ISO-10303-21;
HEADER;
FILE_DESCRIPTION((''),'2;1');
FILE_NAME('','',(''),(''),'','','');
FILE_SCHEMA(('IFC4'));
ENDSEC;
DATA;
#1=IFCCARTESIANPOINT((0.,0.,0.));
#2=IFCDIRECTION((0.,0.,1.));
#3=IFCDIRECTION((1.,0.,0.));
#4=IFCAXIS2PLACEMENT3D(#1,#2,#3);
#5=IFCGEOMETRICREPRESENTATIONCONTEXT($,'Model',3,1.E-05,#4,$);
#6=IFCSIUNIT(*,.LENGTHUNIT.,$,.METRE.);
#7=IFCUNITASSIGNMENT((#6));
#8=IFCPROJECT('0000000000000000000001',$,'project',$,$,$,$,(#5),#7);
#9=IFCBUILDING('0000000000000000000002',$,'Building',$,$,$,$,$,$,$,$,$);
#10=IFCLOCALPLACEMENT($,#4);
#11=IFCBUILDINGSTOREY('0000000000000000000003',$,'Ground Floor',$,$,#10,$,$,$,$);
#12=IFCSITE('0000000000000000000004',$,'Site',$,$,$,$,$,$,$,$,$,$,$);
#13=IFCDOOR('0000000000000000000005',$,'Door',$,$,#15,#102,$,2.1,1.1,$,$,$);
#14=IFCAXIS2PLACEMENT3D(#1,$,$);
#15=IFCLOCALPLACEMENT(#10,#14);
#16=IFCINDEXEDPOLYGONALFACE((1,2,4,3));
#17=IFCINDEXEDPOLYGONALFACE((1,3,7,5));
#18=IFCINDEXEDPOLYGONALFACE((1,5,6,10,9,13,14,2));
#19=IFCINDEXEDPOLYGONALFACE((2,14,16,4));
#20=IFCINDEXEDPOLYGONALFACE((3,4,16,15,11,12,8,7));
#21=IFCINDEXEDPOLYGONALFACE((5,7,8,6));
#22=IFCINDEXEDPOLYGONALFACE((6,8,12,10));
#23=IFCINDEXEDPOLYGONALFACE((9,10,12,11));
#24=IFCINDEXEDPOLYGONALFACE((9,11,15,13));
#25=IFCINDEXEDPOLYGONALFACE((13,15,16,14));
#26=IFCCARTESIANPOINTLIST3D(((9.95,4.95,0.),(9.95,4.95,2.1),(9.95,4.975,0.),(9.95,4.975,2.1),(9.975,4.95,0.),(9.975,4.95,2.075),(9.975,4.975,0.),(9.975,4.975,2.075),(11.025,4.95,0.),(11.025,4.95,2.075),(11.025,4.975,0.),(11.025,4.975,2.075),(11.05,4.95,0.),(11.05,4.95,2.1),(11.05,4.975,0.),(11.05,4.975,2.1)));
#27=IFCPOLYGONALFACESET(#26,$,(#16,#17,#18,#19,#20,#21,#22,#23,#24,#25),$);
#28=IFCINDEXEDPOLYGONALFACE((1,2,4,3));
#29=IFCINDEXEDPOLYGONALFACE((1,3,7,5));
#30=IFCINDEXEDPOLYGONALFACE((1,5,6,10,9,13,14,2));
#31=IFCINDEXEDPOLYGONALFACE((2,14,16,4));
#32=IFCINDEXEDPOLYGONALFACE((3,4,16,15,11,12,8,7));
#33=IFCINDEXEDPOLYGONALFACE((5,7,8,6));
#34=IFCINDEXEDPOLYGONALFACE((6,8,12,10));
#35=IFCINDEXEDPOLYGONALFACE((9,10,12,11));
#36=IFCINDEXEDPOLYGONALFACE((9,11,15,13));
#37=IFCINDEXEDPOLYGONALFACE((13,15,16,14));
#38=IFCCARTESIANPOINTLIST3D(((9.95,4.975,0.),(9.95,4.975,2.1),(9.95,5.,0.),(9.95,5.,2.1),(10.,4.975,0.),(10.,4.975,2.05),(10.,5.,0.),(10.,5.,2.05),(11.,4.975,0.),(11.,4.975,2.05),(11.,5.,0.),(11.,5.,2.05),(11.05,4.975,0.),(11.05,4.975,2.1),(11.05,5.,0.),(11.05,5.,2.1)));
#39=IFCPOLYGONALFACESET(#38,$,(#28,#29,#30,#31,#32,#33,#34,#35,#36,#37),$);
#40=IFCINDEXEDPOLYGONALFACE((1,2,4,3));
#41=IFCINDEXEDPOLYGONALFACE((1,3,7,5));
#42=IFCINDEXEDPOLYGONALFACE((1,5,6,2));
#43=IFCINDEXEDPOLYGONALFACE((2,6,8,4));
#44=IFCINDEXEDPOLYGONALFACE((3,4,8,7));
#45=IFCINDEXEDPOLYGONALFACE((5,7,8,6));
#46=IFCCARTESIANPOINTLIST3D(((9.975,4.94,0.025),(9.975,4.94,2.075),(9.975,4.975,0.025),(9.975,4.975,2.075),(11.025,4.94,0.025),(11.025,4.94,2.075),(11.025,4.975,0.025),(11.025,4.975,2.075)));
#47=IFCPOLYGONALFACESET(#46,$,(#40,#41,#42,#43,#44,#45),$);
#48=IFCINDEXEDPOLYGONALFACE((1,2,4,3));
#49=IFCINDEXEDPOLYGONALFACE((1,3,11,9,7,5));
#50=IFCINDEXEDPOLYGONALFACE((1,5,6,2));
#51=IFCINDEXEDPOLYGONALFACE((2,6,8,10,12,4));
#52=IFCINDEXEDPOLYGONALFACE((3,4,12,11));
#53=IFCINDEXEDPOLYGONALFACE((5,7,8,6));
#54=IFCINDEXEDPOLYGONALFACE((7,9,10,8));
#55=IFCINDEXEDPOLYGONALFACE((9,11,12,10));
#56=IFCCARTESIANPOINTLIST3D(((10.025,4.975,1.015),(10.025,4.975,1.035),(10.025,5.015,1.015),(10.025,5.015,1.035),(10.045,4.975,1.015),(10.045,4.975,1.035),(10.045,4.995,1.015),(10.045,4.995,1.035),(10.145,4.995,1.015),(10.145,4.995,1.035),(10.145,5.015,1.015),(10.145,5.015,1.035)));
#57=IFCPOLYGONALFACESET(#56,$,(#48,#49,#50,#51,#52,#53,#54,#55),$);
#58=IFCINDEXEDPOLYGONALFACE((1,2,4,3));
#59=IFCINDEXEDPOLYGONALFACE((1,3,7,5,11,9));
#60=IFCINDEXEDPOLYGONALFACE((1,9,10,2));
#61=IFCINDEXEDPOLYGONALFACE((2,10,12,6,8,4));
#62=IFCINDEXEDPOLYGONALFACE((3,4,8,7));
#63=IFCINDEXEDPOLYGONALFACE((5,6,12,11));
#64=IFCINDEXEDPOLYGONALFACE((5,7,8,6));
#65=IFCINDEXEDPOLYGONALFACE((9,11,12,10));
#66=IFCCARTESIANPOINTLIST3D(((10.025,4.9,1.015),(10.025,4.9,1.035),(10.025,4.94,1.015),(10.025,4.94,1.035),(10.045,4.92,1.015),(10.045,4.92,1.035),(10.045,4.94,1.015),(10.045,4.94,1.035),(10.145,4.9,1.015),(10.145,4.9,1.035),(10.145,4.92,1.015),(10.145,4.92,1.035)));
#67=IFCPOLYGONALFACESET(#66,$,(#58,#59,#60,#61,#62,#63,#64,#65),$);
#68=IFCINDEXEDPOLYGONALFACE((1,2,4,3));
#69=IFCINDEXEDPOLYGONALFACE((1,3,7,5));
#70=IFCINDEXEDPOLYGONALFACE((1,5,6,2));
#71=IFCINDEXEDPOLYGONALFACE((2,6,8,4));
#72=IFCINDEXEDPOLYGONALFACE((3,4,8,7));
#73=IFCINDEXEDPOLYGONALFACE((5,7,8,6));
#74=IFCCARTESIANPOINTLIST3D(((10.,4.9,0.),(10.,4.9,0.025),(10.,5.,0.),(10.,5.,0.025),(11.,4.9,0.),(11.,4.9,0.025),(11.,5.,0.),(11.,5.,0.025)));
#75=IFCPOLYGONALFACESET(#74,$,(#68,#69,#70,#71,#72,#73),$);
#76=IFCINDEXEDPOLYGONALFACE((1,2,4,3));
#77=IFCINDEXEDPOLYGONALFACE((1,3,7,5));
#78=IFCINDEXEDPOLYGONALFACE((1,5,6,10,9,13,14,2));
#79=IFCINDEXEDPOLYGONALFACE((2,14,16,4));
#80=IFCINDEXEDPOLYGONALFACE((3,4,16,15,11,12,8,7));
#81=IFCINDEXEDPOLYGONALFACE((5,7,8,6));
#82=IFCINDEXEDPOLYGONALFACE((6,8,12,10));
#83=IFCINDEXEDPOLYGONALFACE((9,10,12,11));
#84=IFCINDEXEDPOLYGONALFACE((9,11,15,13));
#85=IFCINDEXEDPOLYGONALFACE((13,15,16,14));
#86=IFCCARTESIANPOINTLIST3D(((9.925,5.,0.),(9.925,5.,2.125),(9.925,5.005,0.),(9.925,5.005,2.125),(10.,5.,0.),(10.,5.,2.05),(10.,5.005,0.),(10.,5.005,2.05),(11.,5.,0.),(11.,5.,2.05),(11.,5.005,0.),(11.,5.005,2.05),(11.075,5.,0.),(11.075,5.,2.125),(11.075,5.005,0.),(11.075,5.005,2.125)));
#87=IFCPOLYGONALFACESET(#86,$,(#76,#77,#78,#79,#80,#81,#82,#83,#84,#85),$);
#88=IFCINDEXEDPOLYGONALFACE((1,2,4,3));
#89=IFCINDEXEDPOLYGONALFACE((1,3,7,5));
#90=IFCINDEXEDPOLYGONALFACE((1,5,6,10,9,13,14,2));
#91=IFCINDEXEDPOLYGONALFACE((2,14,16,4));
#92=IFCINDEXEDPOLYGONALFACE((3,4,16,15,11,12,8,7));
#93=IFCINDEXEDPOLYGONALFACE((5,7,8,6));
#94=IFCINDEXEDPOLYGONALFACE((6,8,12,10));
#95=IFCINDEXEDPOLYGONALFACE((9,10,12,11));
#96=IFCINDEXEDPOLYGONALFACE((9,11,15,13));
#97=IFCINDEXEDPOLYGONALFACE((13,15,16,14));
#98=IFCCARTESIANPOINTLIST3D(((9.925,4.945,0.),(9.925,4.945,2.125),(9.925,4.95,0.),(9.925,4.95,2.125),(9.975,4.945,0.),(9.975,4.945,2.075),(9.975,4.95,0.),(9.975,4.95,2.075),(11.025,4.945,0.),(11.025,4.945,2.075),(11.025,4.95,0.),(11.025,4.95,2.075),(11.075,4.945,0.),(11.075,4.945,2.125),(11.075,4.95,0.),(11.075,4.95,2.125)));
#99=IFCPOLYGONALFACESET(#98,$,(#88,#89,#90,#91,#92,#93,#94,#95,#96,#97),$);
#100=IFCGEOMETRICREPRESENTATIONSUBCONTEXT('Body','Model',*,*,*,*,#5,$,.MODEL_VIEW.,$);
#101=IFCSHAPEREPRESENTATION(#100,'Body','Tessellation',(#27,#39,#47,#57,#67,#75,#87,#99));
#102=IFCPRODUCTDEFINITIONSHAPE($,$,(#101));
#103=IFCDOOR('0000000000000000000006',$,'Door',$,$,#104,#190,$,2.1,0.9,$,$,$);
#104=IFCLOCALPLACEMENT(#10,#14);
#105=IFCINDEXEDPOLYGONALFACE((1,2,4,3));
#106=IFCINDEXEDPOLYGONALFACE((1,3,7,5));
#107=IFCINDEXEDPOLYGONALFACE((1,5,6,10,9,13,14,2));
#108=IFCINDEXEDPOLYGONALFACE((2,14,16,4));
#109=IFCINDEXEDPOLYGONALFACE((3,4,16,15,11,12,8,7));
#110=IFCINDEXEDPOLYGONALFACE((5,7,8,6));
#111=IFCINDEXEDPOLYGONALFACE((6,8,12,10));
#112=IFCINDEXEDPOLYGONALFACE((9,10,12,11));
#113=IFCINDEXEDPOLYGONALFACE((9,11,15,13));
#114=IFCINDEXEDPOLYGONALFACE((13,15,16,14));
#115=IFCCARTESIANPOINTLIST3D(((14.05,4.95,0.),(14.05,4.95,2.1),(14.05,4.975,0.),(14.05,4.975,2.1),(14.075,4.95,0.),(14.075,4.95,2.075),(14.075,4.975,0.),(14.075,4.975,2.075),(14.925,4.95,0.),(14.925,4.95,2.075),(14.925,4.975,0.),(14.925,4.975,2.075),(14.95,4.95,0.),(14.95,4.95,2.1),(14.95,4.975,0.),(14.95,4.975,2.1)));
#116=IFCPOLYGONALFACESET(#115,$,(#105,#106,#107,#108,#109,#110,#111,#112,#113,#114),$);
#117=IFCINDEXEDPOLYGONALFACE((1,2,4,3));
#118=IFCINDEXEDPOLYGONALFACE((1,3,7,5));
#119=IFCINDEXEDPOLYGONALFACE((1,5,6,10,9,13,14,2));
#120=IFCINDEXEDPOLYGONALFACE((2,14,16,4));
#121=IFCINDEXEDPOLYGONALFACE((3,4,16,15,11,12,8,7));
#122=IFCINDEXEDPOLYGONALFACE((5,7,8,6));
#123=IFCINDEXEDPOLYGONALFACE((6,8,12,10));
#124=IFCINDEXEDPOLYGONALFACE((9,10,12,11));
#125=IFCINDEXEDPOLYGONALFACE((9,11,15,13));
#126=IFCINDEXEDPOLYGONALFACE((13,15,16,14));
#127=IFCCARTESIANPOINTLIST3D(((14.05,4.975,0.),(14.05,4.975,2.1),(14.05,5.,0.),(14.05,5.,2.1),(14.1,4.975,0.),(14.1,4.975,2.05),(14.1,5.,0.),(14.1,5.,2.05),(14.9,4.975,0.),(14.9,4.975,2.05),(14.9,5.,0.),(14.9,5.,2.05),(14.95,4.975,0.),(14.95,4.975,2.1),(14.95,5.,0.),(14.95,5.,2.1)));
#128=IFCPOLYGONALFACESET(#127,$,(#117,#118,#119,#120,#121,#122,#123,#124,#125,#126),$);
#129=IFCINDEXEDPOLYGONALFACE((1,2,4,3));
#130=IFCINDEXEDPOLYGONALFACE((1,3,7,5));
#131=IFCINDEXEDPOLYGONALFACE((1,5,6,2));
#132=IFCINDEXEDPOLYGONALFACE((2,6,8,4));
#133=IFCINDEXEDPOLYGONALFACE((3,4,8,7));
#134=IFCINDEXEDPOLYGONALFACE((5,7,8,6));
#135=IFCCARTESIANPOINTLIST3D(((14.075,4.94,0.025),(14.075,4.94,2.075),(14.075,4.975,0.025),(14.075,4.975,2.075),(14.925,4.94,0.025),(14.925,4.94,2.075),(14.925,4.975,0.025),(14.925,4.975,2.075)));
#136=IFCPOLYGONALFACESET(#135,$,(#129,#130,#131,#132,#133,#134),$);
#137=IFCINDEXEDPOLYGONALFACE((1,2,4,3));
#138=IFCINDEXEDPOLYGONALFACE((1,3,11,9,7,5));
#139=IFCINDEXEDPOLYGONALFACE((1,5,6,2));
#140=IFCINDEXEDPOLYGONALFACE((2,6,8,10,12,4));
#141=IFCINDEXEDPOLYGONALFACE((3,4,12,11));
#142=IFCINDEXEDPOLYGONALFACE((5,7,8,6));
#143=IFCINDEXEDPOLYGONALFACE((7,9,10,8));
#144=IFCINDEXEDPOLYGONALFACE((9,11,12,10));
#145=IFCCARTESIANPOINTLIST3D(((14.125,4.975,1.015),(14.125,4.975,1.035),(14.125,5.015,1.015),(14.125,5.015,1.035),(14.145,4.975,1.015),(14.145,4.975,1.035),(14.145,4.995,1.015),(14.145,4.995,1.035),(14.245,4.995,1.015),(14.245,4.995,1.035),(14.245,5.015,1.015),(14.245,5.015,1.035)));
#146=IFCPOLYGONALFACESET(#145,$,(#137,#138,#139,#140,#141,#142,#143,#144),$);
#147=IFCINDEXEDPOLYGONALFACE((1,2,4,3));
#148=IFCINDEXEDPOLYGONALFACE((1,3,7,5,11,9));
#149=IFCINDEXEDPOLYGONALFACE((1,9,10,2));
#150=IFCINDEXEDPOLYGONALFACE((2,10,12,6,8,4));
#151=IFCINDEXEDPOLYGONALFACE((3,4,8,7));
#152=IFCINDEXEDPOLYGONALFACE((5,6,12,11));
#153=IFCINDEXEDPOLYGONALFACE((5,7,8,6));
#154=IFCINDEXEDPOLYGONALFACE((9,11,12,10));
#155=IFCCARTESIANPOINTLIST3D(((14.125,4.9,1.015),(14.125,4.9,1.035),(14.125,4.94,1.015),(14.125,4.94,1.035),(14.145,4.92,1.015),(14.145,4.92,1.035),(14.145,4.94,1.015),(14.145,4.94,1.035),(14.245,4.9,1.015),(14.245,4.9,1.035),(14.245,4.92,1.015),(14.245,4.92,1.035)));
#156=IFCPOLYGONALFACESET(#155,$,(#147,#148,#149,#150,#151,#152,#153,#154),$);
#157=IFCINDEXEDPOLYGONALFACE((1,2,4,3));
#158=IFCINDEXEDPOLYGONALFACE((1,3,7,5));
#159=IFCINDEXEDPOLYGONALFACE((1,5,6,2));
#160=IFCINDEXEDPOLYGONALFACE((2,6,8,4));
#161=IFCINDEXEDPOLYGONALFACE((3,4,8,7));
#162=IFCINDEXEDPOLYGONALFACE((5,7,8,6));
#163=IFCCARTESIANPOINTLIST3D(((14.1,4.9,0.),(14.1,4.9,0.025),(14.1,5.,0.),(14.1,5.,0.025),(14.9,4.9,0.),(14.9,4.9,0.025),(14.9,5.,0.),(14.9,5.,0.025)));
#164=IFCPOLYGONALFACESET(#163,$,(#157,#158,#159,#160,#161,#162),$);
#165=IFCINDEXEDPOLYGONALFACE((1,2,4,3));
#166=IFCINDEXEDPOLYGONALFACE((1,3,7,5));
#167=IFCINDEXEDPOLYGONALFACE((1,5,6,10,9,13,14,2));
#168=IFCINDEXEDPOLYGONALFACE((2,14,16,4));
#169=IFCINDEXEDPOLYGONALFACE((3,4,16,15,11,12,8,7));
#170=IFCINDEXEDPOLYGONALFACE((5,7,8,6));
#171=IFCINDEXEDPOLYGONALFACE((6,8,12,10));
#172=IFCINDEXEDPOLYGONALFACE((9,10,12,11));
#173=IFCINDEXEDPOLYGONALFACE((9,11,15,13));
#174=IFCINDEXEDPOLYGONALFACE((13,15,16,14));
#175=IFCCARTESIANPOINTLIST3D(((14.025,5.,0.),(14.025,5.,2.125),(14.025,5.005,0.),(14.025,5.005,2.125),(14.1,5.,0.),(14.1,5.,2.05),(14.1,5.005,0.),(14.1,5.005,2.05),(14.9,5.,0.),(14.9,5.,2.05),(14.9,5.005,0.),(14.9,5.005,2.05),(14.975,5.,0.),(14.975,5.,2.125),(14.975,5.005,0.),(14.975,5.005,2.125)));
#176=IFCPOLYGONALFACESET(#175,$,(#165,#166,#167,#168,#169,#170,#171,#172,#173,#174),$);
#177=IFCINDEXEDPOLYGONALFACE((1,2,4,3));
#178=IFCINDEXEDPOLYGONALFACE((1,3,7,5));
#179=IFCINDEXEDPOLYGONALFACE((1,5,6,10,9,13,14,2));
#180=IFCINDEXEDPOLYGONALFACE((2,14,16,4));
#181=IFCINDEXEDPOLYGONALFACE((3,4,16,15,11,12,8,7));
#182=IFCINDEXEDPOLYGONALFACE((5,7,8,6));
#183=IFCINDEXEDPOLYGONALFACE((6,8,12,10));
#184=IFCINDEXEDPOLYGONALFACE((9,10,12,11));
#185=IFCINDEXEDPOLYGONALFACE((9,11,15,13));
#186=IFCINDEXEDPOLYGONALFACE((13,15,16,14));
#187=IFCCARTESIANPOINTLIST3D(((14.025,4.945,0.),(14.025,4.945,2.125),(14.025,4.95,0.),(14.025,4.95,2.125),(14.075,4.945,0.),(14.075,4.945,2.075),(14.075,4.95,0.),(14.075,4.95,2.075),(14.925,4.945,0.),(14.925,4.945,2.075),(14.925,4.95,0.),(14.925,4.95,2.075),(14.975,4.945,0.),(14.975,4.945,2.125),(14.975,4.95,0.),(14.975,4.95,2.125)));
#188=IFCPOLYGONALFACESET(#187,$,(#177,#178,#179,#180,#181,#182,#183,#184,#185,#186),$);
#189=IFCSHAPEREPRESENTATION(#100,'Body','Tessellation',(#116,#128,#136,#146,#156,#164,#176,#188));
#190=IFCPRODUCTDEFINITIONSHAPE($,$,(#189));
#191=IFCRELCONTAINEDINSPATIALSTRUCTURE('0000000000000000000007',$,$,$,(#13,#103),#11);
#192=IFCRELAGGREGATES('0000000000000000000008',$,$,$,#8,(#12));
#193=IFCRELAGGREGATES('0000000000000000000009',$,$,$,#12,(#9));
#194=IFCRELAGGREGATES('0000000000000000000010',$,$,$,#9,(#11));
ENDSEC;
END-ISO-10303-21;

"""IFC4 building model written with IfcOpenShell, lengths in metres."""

from ifc_helpers import new_model, si_unit, frame, origin_with_axes, place, context, subcontext, project, spatial, line, indexed_curve, outline, extrude, element, save


model = new_model("IFC4")

# Units and contexts
model_context = context("Model", 3, precision=1e-05, world=origin_with_axes())
body_context = subcontext(model_context, "Body", "Model", "MODEL_VIEW")
ifc_project = project(units=[si_unit("LENGTHUNIT", "METRE")], contexts=[model_context])

# Site, building, storey
site = spatial("IfcSite", under=ifc_project, Name="Site")
building = spatial("IfcBuilding", under=site, Name="Building")
storey_placement = place(None, origin_with_axes())
storey = spatial("IfcBuildingStorey", under=building, at=storey_placement, Name="Ground Floor")

# Doors
door_1_placement = place(storey_placement, frame((11.05, 5.0, 0.0), z_axis=(0.0, 0.0, 1.0), x_axis=(-1.0, 0.0, 0.0)))
element("IfcDoor", 1, at=door_1_placement, inside=storey, Name="Door", OverallHeight=2.1, OverallWidth=1.1, context=body_context, shape_type="SweptSolid", body=[
    extrude(outline(indexed_curve([(0.0, 0.0), (0.0, 2.1), (1.1, 2.1), (1.1, 0.0), (1.075, 0.0), (1.075, 2.075), (0.025, 2.075), (0.025, 0.0)], segments=[line(1, 2, 3, 4, 5, 6, 7, 8, 1)])), frame((0.0, 0.025, 0.0), z_axis=(0.0, -1.0, 0.0), x_axis=(1.0, 0.0, 0.0)), (0.0, 0.0, -1.0), 0.025),
    extrude(outline(indexed_curve([(0.0, 0.0), (0.0, 2.1), (1.1, 2.1), (1.1, 0.0), (1.05, 0.0), (1.05, 2.05), (0.05, 2.05), (0.05, 0.0)], segments=[line(1, 2, 3, 4, 5, 6, 7, 8, 1)])), frame((0.0, 0.0, 0.0), z_axis=(0.0, -1.0, 0.0), x_axis=(1.0, 0.0, 0.0)), (0.0, 0.0, -1.0), 0.025),
    extrude(outline(indexed_curve([(0.0, 0.0), (1.05, 0.0), (1.05, 0.035), (0.0, 0.035)], segments=[line(1, 2, 3, 4, 1)])), frame((0.025, 0.025, 0.025), z_axis=(0.0, 0.0, 1.0), x_axis=(1.0, 0.0, 0.0)), (0.0, 0.0, 1.0), 2.05),
    extrude(outline(indexed_curve([(0.0, 0.0), (0.0, -0.04), (-0.12, -0.04), (-0.12, -0.02), (-0.02, -0.02), (-0.02, 0.0)], segments=[line(1, 2, 3, 4, 5, 6, 1)])), frame((1.025, 0.025, 1.015), z_axis=(0.0, 0.0, 1.0), x_axis=(1.0, 0.0, 0.0)), (0.0, 0.0, 1.0), 0.02),
    extrude(outline(indexed_curve([(0.0, 0.0), (0.0, 0.04), (-0.12, 0.04), (-0.12, 0.02), (-0.02, 0.02), (-0.02, 0.0)], segments=[line(1, 2, 3, 4, 5, 6, 1)])), frame((1.025, 0.06, 1.015), z_axis=(0.0, 0.0, 1.0), x_axis=(1.0, 0.0, 0.0)), (0.0, 0.0, 1.0), 0.02),
    extrude(outline(indexed_curve([(0.0, 0.0), (1.0, 0.0), (1.0, 0.1), (0.0, 0.1)], segments=[line(1, 2, 3, 4, 1)])), frame((0.05, 0.0, 0.0), z_axis=(0.0, 0.0, 1.0), x_axis=(1.0, 0.0, 0.0)), (0.0, 0.0, 1.0), 0.025),
    extrude(outline(indexed_curve([(0.0, 0.0), (0.0, 2.125), (1.15, 2.125), (1.15, 0.0), (1.075, 0.0), (1.075, 2.05), (0.075, 2.05), (0.075, 0.0)], segments=[line(1, 2, 3, 4, 5, 6, 7, 8, 1)])), frame((-0.025, -0.005, 0.0), z_axis=(0.0, -1.0, 0.0), x_axis=(1.0, 0.0, 0.0)), (0.0, 0.0, -1.0), 0.005),
    extrude(outline(indexed_curve([(0.0, 0.0), (0.0, 2.125), (1.15, 2.125), (1.15, 0.0), (1.1, 0.0), (1.1, 2.075), (0.05, 2.075), (0.05, 0.0)], segments=[line(1, 2, 3, 4, 5, 6, 7, 8, 1)])), frame((-0.025, 0.05, 0.0), z_axis=(0.0, -1.0, 0.0), x_axis=(1.0, 0.0, 0.0)), (0.0, 0.0, -1.0), 0.005),
])
door_2_placement = place(storey_placement, frame((14.95, 5.0, 0.0), z_axis=(0.0, 0.0, 1.0), x_axis=(-1.0, 0.0, 0.0)))
element("IfcDoor", 2, at=door_2_placement, inside=storey, Name="Door", OverallHeight=2.1, OverallWidth=0.9, context=body_context, shape_type="SweptSolid", body=[
    extrude(outline(indexed_curve([(0.0, 0.0), (0.0, 2.1), (0.9, 2.1), (0.9, 0.0), (0.875, 0.0), (0.875, 2.075), (0.025, 2.075), (0.025, 0.0)], segments=[line(1, 2, 3, 4, 5, 6, 7, 8, 1)])), frame((0.0, 0.025, 0.0), z_axis=(0.0, -1.0, 0.0), x_axis=(1.0, 0.0, 0.0)), (0.0, 0.0, -1.0), 0.025),
    extrude(outline(indexed_curve([(0.0, 0.0), (0.0, 2.1), (0.9, 2.1), (0.9, 0.0), (0.85, 0.0), (0.85, 2.05), (0.05, 2.05), (0.05, 0.0)], segments=[line(1, 2, 3, 4, 5, 6, 7, 8, 1)])), frame((0.0, 0.0, 0.0), z_axis=(0.0, -1.0, 0.0), x_axis=(1.0, 0.0, 0.0)), (0.0, 0.0, -1.0), 0.025),
    extrude(outline(indexed_curve([(0.0, 0.0), (0.85, 0.0), (0.85, 0.035), (0.0, 0.035)], segments=[line(1, 2, 3, 4, 1)])), frame((0.025, 0.025, 0.025), z_axis=(0.0, 0.0, 1.0), x_axis=(1.0, 0.0, 0.0)), (0.0, 0.0, 1.0), 2.05),
    extrude(outline(indexed_curve([(0.0, 0.0), (0.0, -0.04), (-0.12, -0.04), (-0.12, -0.02), (-0.02, -0.02), (-0.02, 0.0)], segments=[line(1, 2, 3, 4, 5, 6, 1)])), frame((0.825, 0.025, 1.015), z_axis=(0.0, 0.0, 1.0), x_axis=(1.0, 0.0, 0.0)), (0.0, 0.0, 1.0), 0.02),
    extrude(outline(indexed_curve([(0.0, 0.0), (0.0, 0.04), (-0.12, 0.04), (-0.12, 0.02), (-0.02, 0.02), (-0.02, 0.0)], segments=[line(1, 2, 3, 4, 5, 6, 1)])), frame((0.825, 0.06, 1.015), z_axis=(0.0, 0.0, 1.0), x_axis=(1.0, 0.0, 0.0)), (0.0, 0.0, 1.0), 0.02),
    extrude(outline(indexed_curve([(0.0, 0.0), (0.8, 0.0), (0.8, 0.1), (0.0, 0.1)], segments=[line(1, 2, 3, 4, 1)])), frame((0.05, 0.0, 0.0), z_axis=(0.0, 0.0, 1.0), x_axis=(1.0, 0.0, 0.0)), (0.0, 0.0, 1.0), 0.025),
    extrude(outline(indexed_curve([(0.0, 0.0), (0.0, 2.125), (0.95, 2.125), (0.95, 0.0), (0.875, 0.0), (0.875, 2.05), (0.075, 2.05), (0.075, 0.0)], segments=[line(1, 2, 3, 4, 5, 6, 7, 8, 1)])), frame((-0.025, -0.005, 0.0), z_axis=(0.0, -1.0, 0.0), x_axis=(1.0, 0.0, 0.0)), (0.0, 0.0, -1.0), 0.005),
    extrude(outline(indexed_curve([(0.0, 0.0), (0.0, 2.125), (0.95, 2.125), (0.95, 0.0), (0.9, 0.0), (0.9, 2.075), (0.05, 2.075), (0.05, 0.0)], segments=[line(1, 2, 3, 4, 5, 6, 7, 8, 1)])), frame((-0.025, 0.05, 0.0), z_axis=(0.0, -1.0, 0.0), x_axis=(1.0, 0.0, 0.0)), (0.0, 0.0, -1.0), 0.005),
])

save(model, "model.ifc")
